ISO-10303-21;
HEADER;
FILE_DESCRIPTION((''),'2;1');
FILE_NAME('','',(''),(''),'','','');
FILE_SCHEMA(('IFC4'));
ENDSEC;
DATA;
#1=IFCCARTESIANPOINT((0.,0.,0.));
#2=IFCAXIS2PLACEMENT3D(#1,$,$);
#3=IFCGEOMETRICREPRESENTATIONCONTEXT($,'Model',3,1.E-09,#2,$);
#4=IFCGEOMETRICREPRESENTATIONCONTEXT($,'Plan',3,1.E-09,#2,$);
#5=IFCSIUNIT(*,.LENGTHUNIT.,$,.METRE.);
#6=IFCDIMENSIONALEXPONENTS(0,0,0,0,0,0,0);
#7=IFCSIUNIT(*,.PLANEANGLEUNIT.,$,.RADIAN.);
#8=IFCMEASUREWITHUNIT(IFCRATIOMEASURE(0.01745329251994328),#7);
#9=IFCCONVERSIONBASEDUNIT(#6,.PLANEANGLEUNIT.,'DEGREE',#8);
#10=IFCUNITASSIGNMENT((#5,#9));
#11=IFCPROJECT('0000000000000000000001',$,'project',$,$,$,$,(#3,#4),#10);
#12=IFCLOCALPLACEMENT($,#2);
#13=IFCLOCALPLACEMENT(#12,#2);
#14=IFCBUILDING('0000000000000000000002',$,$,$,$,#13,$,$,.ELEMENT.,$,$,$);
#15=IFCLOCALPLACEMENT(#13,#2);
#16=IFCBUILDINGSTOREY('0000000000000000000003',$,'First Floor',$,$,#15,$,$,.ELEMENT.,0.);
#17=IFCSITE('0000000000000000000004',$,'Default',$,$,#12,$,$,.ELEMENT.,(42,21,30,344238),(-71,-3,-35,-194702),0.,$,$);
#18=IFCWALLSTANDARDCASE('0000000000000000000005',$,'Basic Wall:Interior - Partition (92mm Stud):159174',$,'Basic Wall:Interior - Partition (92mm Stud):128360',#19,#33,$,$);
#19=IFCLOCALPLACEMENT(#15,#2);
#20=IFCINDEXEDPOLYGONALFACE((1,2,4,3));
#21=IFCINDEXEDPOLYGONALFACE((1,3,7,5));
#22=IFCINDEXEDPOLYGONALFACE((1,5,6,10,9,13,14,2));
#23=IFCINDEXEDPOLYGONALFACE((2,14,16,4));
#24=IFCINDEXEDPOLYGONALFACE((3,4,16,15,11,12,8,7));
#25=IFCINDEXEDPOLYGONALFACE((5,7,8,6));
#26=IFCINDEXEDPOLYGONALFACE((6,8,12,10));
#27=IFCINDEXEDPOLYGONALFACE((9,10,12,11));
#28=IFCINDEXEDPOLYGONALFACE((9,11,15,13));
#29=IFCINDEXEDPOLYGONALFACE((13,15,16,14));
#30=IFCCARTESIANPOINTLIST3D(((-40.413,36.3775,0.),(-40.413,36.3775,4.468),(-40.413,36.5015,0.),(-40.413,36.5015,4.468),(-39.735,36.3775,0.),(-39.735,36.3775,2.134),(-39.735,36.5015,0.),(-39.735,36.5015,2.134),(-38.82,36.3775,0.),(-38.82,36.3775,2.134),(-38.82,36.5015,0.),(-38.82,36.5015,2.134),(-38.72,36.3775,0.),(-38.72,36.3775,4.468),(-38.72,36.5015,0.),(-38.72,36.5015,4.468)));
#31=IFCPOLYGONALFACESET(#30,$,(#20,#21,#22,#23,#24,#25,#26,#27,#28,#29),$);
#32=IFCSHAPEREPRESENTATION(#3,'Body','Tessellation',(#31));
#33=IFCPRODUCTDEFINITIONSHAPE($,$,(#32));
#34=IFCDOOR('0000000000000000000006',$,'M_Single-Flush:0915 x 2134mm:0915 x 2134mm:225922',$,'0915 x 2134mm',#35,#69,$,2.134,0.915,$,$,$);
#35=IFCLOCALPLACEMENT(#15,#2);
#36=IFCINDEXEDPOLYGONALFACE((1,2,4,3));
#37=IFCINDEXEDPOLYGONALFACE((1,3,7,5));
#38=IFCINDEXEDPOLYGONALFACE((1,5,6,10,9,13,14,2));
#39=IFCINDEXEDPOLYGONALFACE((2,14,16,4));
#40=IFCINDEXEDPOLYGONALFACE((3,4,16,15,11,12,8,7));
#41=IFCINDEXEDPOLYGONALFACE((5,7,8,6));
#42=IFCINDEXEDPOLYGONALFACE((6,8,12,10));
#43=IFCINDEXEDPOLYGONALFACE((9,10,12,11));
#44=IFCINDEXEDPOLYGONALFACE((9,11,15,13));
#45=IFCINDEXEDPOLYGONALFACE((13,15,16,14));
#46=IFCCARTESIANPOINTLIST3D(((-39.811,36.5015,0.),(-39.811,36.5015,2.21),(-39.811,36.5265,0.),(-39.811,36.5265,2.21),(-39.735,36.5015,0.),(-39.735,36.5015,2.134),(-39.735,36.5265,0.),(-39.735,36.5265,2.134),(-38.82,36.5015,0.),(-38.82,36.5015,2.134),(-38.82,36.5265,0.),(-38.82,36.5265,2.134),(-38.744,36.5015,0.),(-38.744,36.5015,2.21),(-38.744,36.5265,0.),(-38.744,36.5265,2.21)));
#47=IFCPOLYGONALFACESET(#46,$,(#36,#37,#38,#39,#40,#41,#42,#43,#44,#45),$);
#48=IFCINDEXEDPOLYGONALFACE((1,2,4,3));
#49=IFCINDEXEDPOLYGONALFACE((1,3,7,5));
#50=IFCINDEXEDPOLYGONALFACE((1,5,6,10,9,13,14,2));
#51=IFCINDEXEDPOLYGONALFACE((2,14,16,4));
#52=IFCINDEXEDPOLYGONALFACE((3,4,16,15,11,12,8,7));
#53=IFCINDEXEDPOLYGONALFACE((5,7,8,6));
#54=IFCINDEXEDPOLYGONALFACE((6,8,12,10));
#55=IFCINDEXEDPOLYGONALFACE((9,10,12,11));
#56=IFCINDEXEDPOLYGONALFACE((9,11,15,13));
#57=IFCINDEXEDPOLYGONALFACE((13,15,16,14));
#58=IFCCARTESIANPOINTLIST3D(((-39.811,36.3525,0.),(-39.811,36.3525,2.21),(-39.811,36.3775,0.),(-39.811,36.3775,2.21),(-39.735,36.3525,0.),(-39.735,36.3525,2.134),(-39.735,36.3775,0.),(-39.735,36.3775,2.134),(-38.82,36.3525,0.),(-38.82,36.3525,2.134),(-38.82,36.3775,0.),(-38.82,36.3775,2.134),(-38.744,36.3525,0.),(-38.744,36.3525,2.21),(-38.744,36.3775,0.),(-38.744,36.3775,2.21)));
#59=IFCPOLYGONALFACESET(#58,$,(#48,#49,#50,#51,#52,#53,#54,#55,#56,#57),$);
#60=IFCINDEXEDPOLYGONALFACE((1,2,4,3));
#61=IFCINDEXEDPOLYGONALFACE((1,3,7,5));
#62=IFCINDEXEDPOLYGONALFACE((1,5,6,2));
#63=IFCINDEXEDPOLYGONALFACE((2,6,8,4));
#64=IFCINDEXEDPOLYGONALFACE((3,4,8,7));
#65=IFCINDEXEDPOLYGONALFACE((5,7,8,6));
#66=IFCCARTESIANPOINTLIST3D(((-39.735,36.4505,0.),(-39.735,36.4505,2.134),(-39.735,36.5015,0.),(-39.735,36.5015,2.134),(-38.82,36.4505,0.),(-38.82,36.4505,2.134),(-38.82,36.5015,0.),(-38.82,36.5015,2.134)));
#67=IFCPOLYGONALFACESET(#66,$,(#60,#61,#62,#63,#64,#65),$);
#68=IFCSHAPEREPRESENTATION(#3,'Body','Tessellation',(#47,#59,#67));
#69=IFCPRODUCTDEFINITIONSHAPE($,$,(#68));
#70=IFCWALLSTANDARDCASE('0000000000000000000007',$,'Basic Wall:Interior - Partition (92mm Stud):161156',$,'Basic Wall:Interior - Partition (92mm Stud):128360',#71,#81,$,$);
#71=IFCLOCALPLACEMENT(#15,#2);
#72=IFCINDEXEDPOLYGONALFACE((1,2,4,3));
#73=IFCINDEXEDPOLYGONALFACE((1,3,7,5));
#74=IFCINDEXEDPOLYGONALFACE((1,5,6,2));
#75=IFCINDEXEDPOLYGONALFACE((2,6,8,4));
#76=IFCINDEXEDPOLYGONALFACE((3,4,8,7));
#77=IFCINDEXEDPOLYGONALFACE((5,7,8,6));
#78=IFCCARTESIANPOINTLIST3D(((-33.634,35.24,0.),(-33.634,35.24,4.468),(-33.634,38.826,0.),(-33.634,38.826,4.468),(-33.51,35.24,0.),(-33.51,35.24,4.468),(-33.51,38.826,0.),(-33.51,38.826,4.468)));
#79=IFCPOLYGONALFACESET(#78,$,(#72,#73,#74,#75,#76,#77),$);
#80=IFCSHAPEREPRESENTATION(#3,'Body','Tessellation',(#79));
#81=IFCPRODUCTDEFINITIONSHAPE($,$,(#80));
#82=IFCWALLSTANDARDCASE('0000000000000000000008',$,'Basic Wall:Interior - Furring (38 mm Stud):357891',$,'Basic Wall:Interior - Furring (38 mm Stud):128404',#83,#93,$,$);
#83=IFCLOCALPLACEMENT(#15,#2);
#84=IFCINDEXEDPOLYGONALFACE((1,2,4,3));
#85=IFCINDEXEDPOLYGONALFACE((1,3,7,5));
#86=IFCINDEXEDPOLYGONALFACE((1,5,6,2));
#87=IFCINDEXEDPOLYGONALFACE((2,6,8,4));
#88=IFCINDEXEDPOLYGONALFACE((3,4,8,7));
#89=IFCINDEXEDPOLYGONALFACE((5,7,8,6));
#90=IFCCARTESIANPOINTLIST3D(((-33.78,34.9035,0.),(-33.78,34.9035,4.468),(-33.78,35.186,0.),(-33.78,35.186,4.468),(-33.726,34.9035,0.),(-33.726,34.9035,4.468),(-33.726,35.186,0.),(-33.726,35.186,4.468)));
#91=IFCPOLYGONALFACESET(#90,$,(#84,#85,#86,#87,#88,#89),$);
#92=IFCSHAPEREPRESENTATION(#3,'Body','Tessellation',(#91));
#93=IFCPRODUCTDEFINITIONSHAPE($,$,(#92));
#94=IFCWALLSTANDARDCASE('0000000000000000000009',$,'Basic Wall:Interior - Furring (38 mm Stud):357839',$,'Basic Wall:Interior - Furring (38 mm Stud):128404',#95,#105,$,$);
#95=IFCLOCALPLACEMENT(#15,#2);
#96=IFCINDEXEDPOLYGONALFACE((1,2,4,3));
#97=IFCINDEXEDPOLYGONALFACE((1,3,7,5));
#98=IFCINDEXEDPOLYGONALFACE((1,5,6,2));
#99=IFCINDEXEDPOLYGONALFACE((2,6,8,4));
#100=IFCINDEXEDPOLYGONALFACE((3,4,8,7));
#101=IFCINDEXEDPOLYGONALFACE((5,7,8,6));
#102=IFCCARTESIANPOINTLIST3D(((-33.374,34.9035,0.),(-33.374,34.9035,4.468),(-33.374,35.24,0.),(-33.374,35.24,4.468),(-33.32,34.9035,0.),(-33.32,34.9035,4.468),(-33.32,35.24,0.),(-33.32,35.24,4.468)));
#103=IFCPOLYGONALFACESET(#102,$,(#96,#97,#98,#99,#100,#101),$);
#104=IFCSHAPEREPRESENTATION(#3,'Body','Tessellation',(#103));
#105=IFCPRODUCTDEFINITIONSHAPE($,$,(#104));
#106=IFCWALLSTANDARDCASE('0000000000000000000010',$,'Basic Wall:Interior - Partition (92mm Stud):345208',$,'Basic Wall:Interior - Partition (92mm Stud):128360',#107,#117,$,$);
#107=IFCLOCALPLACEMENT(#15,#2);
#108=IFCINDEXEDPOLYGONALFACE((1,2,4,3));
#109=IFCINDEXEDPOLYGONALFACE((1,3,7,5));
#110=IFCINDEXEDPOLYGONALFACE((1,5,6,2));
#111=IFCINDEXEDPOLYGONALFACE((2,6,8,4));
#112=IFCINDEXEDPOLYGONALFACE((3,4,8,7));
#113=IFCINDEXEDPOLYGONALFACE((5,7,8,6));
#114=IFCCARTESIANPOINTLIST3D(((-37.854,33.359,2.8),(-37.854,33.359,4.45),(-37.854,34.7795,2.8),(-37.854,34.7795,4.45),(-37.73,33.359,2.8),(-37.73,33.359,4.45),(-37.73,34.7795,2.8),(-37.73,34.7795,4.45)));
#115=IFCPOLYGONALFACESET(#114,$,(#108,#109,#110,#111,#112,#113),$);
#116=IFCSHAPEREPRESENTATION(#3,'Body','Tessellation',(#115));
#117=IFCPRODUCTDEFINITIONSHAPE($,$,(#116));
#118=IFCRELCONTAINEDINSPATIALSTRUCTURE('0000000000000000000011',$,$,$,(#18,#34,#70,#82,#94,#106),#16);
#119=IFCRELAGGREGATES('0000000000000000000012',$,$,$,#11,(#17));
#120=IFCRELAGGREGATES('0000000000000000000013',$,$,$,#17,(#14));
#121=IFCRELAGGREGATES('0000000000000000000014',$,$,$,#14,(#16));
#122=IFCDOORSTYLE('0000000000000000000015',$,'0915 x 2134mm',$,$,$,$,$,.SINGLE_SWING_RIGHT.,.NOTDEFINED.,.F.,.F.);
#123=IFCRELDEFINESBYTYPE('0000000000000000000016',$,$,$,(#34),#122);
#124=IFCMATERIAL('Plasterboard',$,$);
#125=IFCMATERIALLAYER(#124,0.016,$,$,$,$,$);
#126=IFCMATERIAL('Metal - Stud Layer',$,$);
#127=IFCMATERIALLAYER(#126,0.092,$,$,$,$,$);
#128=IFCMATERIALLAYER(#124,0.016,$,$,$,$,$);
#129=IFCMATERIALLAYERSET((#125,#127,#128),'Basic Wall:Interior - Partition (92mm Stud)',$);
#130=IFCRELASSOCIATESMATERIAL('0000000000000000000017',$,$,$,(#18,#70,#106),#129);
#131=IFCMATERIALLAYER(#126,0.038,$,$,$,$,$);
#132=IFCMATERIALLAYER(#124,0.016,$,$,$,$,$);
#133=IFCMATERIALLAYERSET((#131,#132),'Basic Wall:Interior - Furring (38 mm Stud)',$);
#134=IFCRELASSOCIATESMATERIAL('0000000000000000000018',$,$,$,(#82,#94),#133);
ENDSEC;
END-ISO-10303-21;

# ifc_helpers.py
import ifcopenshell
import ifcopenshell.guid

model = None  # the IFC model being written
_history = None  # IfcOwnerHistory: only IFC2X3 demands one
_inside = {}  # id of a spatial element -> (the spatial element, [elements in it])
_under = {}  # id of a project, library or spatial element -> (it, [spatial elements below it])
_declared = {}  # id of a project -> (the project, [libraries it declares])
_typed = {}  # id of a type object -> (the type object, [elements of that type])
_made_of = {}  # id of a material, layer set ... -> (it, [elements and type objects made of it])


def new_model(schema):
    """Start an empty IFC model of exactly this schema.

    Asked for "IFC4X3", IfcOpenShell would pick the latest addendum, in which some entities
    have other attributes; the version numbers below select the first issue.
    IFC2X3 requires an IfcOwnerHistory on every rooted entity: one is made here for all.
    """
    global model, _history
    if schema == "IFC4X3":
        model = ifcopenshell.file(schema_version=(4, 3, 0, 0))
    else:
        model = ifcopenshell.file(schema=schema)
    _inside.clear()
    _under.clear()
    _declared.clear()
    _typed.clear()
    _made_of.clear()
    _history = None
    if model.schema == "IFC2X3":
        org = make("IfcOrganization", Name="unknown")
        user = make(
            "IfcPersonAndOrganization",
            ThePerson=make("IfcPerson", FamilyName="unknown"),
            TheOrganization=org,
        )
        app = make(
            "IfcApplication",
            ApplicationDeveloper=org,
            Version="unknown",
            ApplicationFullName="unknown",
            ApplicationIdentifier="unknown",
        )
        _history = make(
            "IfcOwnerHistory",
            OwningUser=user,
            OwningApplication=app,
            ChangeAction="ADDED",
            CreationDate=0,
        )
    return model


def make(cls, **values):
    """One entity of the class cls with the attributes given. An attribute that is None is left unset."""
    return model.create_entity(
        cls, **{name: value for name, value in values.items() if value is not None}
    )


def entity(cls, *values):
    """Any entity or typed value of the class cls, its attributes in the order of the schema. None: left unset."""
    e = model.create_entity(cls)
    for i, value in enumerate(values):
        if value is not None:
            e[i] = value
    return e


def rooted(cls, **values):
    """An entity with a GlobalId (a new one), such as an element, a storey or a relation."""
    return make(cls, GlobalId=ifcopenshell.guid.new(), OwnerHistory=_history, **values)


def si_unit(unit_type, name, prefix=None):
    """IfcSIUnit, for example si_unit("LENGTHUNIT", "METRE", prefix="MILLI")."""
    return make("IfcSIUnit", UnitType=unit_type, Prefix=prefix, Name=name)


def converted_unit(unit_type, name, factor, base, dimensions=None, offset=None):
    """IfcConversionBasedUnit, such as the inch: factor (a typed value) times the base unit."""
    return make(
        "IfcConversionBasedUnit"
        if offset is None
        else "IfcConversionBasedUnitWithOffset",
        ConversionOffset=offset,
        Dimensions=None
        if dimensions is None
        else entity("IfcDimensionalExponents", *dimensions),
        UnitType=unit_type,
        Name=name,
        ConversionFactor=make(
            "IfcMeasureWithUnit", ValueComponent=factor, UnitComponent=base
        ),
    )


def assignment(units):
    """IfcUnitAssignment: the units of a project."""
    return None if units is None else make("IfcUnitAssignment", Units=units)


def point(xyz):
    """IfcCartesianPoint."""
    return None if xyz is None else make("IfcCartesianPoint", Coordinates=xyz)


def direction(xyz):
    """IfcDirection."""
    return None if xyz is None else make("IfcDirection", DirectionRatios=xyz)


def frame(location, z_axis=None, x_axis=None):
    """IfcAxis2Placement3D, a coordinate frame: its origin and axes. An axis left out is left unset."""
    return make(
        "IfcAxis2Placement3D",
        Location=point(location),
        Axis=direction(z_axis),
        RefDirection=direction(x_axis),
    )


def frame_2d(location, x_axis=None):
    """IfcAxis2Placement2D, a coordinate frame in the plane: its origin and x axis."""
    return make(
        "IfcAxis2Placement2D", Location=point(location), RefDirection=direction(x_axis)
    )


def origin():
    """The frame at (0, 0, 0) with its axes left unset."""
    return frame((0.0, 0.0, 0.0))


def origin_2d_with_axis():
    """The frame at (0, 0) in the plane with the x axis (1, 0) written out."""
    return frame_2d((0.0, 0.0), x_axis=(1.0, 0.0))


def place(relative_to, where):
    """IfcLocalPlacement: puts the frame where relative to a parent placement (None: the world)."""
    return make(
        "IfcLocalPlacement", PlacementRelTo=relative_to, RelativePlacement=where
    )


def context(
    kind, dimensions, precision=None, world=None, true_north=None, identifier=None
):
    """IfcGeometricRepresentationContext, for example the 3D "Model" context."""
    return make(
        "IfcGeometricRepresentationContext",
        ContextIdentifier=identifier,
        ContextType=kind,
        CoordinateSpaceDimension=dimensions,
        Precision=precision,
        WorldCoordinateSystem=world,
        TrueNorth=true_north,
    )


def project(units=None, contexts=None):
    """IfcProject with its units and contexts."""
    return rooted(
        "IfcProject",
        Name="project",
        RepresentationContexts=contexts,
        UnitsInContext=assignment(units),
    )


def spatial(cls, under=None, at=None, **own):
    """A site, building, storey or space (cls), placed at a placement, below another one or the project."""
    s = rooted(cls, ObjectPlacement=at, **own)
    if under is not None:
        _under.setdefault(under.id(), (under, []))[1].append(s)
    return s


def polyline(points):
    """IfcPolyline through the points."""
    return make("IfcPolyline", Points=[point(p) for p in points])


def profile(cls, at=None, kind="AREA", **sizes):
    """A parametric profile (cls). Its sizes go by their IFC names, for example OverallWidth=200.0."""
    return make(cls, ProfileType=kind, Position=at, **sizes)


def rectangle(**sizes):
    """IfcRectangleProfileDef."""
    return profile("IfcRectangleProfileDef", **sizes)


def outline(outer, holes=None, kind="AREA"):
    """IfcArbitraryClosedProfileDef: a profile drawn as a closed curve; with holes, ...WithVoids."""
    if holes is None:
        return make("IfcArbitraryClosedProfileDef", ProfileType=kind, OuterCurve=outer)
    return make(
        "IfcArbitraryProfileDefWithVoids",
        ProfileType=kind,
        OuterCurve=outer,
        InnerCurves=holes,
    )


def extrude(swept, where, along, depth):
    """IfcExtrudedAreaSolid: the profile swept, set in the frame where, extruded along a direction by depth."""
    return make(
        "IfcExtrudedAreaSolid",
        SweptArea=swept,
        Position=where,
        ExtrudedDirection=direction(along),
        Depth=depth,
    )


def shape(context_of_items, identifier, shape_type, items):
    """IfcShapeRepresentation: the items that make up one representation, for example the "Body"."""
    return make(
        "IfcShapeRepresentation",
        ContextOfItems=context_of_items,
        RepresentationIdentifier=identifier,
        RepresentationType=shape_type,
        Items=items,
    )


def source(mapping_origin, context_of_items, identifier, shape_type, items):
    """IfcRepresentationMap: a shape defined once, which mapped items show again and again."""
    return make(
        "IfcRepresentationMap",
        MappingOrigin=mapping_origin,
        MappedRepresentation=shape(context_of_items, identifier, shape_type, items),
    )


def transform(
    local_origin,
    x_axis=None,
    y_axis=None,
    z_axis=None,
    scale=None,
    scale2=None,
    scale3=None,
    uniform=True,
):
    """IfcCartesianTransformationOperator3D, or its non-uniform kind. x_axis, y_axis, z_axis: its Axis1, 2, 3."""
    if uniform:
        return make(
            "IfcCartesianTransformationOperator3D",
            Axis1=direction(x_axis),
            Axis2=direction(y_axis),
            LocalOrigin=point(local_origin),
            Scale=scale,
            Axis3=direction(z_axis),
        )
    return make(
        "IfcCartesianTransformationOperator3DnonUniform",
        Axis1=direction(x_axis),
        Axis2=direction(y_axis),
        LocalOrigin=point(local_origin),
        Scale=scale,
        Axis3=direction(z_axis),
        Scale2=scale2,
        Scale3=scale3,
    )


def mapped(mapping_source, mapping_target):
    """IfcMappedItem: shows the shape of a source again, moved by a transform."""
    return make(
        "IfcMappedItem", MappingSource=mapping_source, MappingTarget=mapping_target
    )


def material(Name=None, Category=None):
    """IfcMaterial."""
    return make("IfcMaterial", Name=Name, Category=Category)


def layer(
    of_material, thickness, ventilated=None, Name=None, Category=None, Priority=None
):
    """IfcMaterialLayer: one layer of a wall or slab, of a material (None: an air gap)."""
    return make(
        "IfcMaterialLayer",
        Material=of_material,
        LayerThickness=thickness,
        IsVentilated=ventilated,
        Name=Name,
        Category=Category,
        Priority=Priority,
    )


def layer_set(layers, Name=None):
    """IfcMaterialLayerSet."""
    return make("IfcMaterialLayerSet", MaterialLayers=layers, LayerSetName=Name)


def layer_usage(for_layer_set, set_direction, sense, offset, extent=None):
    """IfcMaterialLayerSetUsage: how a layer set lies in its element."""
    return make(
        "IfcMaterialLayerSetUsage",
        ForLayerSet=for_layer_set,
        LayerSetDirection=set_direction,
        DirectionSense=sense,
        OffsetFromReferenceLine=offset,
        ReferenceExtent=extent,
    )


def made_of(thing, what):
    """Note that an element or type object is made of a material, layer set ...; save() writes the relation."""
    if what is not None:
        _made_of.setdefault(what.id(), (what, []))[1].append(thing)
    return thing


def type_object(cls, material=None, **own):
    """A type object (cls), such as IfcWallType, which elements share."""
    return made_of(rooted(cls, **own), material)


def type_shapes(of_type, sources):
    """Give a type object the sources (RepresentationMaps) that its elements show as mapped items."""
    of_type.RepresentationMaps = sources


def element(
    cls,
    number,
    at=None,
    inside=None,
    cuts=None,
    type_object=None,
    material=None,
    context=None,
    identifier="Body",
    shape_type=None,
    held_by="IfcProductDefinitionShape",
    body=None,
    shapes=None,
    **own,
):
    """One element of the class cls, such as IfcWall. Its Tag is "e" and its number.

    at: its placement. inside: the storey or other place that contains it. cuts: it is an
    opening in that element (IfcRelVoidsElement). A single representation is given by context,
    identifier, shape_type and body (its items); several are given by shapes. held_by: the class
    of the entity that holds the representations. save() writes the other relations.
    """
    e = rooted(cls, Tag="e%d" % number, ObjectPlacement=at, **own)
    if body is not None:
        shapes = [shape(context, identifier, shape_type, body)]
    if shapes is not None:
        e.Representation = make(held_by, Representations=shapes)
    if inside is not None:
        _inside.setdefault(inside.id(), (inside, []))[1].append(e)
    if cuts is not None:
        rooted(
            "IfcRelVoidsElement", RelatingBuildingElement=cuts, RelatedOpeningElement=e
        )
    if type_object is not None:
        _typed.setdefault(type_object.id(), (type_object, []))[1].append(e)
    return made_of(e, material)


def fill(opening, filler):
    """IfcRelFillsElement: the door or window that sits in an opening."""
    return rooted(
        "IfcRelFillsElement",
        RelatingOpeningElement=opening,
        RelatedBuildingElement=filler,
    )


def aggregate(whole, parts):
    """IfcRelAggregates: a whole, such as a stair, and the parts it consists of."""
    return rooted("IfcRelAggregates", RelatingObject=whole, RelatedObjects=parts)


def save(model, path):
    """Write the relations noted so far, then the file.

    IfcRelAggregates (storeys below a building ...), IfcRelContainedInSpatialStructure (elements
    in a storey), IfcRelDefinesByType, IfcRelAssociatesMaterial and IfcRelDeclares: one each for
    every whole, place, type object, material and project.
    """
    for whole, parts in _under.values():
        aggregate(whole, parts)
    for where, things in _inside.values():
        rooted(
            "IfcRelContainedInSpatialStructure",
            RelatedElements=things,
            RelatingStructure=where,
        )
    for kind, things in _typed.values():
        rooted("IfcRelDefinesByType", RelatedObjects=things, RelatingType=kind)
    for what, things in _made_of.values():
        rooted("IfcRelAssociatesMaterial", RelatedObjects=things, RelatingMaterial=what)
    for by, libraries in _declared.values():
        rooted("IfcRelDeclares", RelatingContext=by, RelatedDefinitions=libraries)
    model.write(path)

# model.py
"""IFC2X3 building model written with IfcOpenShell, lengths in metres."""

from ifc_helpers import new_model, entity, si_unit, converted_unit, frame, frame_2d, origin, origin_2d_with_axis, place, context, project, spatial, polyline, rectangle, outline, extrude, source, transform, mapped, material, layer, layer_set, layer_usage, type_object, type_shapes, element, fill, save


model = new_model("IFC2X3")

# Units and contexts
model_context = context("Model", 3, precision=1e-09, world=origin())
plan_context = context("Plan", 3, precision=1e-09, world=origin())
ifc_project = project(units=[si_unit("LENGTHUNIT", "METRE"), converted_unit("PLANEANGLEUNIT", "DEGREE", entity("IfcRatioMeasure", 0.01745329251994328), si_unit("PLANEANGLEUNIT", "RADIAN"), dimensions=[0, 0, 0, 0, 0, 0, 0])], contexts=[model_context, plan_context])

# Site, building, storey
site_placement = place(None, origin())
site = spatial("IfcSite", under=ifc_project, at=site_placement, Name="Default", CompositionType="ELEMENT", RefLatitude=(42, 21, 30, 344238), RefLongitude=(-71, -3, -35, -194702), RefElevation=0.0)
building_placement = place(site_placement, origin())
building = spatial("IfcBuilding", under=site, at=building_placement, CompositionType="ELEMENT")
storey_placement = place(building_placement, origin())
storey = spatial("IfcBuildingStorey", under=building, at=storey_placement, Name="First Floor", CompositionType="ELEMENT", Elevation=0.0)

# Shared definitions
ifc_material_1 = material(Name="Plasterboard")
ifc_layer_1 = layer(ifc_material_1, 0.016)
ifc_material_2 = material(Name="Metal - Stud Layer")
ifc_layer_2 = layer(ifc_material_2, 0.092)
ifc_layer_3 = layer(ifc_material_1, 0.016)
ifc_layer_set_1 = layer_set([ifc_layer_1, ifc_layer_2, ifc_layer_3], Name="Basic Wall:Interior - Partition (92mm Stud)")
ifc_layer_usage_1 = layer_usage(ifc_layer_set_1, "AXIS2", "NEGATIVE", 0.062)
ifc_layer_4 = layer(ifc_material_2, 0.038)
ifc_layer_5 = layer(ifc_material_1, 0.016)
ifc_layer_set_2 = layer_set([ifc_layer_4, ifc_layer_5], Name="Basic Wall:Interior - Furring (38 mm Stud)")
ifc_layer_usage_2 = layer_usage(ifc_layer_set_2, "AXIS2", "NEGATIVE", 0.027)

# Wall, opening, door
wall_1_placement = place(storey_placement, frame((-38.72, 36.4395, 0.0), z_axis=(0.0, 0.0, 1.0), x_axis=(-1.0, 0.0, 0.0)))
wall_1 = element("IfcWallStandardCase", 1, at=wall_1_placement, inside=storey, material=ifc_layer_usage_1, Name="Basic Wall:Interior - Partition (92mm Stud):159174", ObjectType="Basic Wall:Interior - Partition (92mm Stud):128360", context=model_context, shape_type="SweptSolid", body=[
    extrude(rectangle(XDim=1.693, YDim=0.124, at=frame_2d((0.8465, 0.0), x_axis=(-1.0, 0.0))), origin(), (0.0, 0.0, 1.0), 4.468),
])
opening_placement = place(wall_1_placement, frame((1.015, 0.062, 0.0)))
opening = element("IfcOpeningElement", 2, at=opening_placement, cuts=wall_1, ObjectType="Opening", context=model_context, shape_type="SweptSolid", body=[
    extrude(rectangle(XDim=0.915, YDim=2.134, at=frame_2d((1.067, 0.4575), x_axis=(0.0, 1.0))), frame((0.0, 0.0, 0.0), z_axis=(0.0, -1.0, 0.0), x_axis=(0.0, 0.0, 1.0)), (0.0, 0.0, 1.0), 0.124),
])
door_style_1 = type_object("IfcDoorStyle", Name="0915 x 2134mm", ConstructionType="NOTDEFINED", OperationType="SINGLE_SWING_RIGHT", ParameterTakesPrecedence=False, Sizeable=False)
shared_shape_1 = source(origin(), model_context, "Body", "SweptSolid", [
    extrude(outline(polyline([(-0.5335, -1.124), (0.5335, -1.124), (0.5335, 1.086), (0.4575, 1.086), (0.4575, -1.048), (-0.4575, -1.048), (-0.4575, 1.086), (-0.5335, 1.086), (-0.5335, -1.124)])), frame((0.4575, 0.124, 1.086), z_axis=(0.0, 1.0, 0.0), x_axis=(1.0, 0.0, 0.0)), (0.0, 0.0, 1.0), 0.025),
    extrude(outline(polyline([(-1.124, -0.5335), (1.086, -0.5335), (1.086, -0.4575), (-1.048, -0.4575), (-1.048, 0.4575), (1.086, 0.4575), (1.086, 0.5335), (-1.124, 0.5335), (-1.124, -0.5335)])), frame((0.4575, -0.025, 1.086), z_axis=(0.0, 1.0, 0.0), x_axis=(0.0, 0.0, -1.0)), (0.0, 0.0, 1.0), 0.025),
    extrude(rectangle(XDim=0.051, YDim=0.915, at=origin_2d_with_axis()), frame((0.4575, 0.0985, 0.0), z_axis=(0.0, 0.0, 1.0), x_axis=(0.0, 1.0, 0.0)), (0.0, 0.0, 1.0), 2.134),
])
type_shapes(door_style_1, [shared_shape_1])
door_1_placement = place(opening_placement, frame((0.0, 0.0, 0.0), z_axis=(0.0, 0.0, 1.0), x_axis=(-1.0, 0.0, 0.0)))
door_1 = element("IfcDoor", 3, at=door_1_placement, inside=storey, type_object=door_style_1, Name="M_Single-Flush:0915 x 2134mm:0915 x 2134mm:225922", ObjectType="0915 x 2134mm", OverallHeight=2.134, OverallWidth=0.915, context=model_context, shape_type="MappedRepresentation", body=[
    mapped(shared_shape_1, transform((0.0, 0.0, 0.0), scale=1.0)),
])
fill(opening, door_1)

# Walls
wall_2_placement = place(storey_placement, frame((-33.572, 38.826, 0.0), z_axis=(0.0, 0.0, 1.0), x_axis=(0.0, -1.0, 0.0)))
element("IfcWallStandardCase", 4, at=wall_2_placement, inside=storey, material=ifc_layer_usage_1, Name="Basic Wall:Interior - Partition (92mm Stud):161156", ObjectType="Basic Wall:Interior - Partition (92mm Stud):128360", context=model_context, shape_type="SweptSolid", body=[
    extrude(rectangle(XDim=3.586, YDim=0.124, at=frame_2d((1.793, 0.0), x_axis=(-1.0, 0.0))), origin(), (0.0, 0.0, 1.0), 4.468),
])
wall_3_placement = place(storey_placement, frame((-33.753, 35.186, 0.0), z_axis=(0.0, 0.0, 1.0), x_axis=(0.0, -1.0, 0.0)))
element("IfcWallStandardCase", 5, at=wall_3_placement, inside=storey, material=ifc_layer_usage_2, Name="Basic Wall:Interior - Furring (38 mm Stud):357891", ObjectType="Basic Wall:Interior - Furring (38 mm Stud):128404", context=model_context, shape_type="SweptSolid", body=[
    extrude(rectangle(XDim=0.2825, YDim=0.054, at=frame_2d((0.1412, 0.0), x_axis=(-1.0, 0.0))), origin(), (0.0, 0.0, 1.0), 4.468),
])
wall_4_placement = place(storey_placement, frame((-33.347, 34.9035, 0.0), z_axis=(0.0, 0.0, 1.0), x_axis=(0.0, 1.0, 0.0)))
element("IfcWallStandardCase", 6, at=wall_4_placement, inside=storey, material=ifc_layer_usage_2, Name="Basic Wall:Interior - Furring (38 mm Stud):357839", ObjectType="Basic Wall:Interior - Furring (38 mm Stud):128404", context=model_context, shape_type="SweptSolid", body=[
    extrude(rectangle(XDim=0.3365, YDim=0.054, at=frame_2d((0.1682, 0.0), x_axis=(-1.0, 0.0))), origin(), (0.0, 0.0, 1.0), 4.468),
])
wall_5_placement = place(storey_placement, frame((-37.792, 34.7795, 2.8), z_axis=(0.0, 0.0, 1.0), x_axis=(0.0, -1.0, 0.0)))
element("IfcWallStandardCase", 7, at=wall_5_placement, inside=storey, material=ifc_layer_usage_1, Name="Basic Wall:Interior - Partition (92mm Stud):345208", ObjectType="Basic Wall:Interior - Partition (92mm Stud):128360", context=model_context, shape_type="SweptSolid", body=[
    extrude(rectangle(XDim=1.4205, YDim=0.124, at=frame_2d((0.7103, 0.0), x_axis=(-1.0, 0.0))), origin(), (0.0, 0.0, 1.0), 1.65),
])

save(model, "model.ifc")
